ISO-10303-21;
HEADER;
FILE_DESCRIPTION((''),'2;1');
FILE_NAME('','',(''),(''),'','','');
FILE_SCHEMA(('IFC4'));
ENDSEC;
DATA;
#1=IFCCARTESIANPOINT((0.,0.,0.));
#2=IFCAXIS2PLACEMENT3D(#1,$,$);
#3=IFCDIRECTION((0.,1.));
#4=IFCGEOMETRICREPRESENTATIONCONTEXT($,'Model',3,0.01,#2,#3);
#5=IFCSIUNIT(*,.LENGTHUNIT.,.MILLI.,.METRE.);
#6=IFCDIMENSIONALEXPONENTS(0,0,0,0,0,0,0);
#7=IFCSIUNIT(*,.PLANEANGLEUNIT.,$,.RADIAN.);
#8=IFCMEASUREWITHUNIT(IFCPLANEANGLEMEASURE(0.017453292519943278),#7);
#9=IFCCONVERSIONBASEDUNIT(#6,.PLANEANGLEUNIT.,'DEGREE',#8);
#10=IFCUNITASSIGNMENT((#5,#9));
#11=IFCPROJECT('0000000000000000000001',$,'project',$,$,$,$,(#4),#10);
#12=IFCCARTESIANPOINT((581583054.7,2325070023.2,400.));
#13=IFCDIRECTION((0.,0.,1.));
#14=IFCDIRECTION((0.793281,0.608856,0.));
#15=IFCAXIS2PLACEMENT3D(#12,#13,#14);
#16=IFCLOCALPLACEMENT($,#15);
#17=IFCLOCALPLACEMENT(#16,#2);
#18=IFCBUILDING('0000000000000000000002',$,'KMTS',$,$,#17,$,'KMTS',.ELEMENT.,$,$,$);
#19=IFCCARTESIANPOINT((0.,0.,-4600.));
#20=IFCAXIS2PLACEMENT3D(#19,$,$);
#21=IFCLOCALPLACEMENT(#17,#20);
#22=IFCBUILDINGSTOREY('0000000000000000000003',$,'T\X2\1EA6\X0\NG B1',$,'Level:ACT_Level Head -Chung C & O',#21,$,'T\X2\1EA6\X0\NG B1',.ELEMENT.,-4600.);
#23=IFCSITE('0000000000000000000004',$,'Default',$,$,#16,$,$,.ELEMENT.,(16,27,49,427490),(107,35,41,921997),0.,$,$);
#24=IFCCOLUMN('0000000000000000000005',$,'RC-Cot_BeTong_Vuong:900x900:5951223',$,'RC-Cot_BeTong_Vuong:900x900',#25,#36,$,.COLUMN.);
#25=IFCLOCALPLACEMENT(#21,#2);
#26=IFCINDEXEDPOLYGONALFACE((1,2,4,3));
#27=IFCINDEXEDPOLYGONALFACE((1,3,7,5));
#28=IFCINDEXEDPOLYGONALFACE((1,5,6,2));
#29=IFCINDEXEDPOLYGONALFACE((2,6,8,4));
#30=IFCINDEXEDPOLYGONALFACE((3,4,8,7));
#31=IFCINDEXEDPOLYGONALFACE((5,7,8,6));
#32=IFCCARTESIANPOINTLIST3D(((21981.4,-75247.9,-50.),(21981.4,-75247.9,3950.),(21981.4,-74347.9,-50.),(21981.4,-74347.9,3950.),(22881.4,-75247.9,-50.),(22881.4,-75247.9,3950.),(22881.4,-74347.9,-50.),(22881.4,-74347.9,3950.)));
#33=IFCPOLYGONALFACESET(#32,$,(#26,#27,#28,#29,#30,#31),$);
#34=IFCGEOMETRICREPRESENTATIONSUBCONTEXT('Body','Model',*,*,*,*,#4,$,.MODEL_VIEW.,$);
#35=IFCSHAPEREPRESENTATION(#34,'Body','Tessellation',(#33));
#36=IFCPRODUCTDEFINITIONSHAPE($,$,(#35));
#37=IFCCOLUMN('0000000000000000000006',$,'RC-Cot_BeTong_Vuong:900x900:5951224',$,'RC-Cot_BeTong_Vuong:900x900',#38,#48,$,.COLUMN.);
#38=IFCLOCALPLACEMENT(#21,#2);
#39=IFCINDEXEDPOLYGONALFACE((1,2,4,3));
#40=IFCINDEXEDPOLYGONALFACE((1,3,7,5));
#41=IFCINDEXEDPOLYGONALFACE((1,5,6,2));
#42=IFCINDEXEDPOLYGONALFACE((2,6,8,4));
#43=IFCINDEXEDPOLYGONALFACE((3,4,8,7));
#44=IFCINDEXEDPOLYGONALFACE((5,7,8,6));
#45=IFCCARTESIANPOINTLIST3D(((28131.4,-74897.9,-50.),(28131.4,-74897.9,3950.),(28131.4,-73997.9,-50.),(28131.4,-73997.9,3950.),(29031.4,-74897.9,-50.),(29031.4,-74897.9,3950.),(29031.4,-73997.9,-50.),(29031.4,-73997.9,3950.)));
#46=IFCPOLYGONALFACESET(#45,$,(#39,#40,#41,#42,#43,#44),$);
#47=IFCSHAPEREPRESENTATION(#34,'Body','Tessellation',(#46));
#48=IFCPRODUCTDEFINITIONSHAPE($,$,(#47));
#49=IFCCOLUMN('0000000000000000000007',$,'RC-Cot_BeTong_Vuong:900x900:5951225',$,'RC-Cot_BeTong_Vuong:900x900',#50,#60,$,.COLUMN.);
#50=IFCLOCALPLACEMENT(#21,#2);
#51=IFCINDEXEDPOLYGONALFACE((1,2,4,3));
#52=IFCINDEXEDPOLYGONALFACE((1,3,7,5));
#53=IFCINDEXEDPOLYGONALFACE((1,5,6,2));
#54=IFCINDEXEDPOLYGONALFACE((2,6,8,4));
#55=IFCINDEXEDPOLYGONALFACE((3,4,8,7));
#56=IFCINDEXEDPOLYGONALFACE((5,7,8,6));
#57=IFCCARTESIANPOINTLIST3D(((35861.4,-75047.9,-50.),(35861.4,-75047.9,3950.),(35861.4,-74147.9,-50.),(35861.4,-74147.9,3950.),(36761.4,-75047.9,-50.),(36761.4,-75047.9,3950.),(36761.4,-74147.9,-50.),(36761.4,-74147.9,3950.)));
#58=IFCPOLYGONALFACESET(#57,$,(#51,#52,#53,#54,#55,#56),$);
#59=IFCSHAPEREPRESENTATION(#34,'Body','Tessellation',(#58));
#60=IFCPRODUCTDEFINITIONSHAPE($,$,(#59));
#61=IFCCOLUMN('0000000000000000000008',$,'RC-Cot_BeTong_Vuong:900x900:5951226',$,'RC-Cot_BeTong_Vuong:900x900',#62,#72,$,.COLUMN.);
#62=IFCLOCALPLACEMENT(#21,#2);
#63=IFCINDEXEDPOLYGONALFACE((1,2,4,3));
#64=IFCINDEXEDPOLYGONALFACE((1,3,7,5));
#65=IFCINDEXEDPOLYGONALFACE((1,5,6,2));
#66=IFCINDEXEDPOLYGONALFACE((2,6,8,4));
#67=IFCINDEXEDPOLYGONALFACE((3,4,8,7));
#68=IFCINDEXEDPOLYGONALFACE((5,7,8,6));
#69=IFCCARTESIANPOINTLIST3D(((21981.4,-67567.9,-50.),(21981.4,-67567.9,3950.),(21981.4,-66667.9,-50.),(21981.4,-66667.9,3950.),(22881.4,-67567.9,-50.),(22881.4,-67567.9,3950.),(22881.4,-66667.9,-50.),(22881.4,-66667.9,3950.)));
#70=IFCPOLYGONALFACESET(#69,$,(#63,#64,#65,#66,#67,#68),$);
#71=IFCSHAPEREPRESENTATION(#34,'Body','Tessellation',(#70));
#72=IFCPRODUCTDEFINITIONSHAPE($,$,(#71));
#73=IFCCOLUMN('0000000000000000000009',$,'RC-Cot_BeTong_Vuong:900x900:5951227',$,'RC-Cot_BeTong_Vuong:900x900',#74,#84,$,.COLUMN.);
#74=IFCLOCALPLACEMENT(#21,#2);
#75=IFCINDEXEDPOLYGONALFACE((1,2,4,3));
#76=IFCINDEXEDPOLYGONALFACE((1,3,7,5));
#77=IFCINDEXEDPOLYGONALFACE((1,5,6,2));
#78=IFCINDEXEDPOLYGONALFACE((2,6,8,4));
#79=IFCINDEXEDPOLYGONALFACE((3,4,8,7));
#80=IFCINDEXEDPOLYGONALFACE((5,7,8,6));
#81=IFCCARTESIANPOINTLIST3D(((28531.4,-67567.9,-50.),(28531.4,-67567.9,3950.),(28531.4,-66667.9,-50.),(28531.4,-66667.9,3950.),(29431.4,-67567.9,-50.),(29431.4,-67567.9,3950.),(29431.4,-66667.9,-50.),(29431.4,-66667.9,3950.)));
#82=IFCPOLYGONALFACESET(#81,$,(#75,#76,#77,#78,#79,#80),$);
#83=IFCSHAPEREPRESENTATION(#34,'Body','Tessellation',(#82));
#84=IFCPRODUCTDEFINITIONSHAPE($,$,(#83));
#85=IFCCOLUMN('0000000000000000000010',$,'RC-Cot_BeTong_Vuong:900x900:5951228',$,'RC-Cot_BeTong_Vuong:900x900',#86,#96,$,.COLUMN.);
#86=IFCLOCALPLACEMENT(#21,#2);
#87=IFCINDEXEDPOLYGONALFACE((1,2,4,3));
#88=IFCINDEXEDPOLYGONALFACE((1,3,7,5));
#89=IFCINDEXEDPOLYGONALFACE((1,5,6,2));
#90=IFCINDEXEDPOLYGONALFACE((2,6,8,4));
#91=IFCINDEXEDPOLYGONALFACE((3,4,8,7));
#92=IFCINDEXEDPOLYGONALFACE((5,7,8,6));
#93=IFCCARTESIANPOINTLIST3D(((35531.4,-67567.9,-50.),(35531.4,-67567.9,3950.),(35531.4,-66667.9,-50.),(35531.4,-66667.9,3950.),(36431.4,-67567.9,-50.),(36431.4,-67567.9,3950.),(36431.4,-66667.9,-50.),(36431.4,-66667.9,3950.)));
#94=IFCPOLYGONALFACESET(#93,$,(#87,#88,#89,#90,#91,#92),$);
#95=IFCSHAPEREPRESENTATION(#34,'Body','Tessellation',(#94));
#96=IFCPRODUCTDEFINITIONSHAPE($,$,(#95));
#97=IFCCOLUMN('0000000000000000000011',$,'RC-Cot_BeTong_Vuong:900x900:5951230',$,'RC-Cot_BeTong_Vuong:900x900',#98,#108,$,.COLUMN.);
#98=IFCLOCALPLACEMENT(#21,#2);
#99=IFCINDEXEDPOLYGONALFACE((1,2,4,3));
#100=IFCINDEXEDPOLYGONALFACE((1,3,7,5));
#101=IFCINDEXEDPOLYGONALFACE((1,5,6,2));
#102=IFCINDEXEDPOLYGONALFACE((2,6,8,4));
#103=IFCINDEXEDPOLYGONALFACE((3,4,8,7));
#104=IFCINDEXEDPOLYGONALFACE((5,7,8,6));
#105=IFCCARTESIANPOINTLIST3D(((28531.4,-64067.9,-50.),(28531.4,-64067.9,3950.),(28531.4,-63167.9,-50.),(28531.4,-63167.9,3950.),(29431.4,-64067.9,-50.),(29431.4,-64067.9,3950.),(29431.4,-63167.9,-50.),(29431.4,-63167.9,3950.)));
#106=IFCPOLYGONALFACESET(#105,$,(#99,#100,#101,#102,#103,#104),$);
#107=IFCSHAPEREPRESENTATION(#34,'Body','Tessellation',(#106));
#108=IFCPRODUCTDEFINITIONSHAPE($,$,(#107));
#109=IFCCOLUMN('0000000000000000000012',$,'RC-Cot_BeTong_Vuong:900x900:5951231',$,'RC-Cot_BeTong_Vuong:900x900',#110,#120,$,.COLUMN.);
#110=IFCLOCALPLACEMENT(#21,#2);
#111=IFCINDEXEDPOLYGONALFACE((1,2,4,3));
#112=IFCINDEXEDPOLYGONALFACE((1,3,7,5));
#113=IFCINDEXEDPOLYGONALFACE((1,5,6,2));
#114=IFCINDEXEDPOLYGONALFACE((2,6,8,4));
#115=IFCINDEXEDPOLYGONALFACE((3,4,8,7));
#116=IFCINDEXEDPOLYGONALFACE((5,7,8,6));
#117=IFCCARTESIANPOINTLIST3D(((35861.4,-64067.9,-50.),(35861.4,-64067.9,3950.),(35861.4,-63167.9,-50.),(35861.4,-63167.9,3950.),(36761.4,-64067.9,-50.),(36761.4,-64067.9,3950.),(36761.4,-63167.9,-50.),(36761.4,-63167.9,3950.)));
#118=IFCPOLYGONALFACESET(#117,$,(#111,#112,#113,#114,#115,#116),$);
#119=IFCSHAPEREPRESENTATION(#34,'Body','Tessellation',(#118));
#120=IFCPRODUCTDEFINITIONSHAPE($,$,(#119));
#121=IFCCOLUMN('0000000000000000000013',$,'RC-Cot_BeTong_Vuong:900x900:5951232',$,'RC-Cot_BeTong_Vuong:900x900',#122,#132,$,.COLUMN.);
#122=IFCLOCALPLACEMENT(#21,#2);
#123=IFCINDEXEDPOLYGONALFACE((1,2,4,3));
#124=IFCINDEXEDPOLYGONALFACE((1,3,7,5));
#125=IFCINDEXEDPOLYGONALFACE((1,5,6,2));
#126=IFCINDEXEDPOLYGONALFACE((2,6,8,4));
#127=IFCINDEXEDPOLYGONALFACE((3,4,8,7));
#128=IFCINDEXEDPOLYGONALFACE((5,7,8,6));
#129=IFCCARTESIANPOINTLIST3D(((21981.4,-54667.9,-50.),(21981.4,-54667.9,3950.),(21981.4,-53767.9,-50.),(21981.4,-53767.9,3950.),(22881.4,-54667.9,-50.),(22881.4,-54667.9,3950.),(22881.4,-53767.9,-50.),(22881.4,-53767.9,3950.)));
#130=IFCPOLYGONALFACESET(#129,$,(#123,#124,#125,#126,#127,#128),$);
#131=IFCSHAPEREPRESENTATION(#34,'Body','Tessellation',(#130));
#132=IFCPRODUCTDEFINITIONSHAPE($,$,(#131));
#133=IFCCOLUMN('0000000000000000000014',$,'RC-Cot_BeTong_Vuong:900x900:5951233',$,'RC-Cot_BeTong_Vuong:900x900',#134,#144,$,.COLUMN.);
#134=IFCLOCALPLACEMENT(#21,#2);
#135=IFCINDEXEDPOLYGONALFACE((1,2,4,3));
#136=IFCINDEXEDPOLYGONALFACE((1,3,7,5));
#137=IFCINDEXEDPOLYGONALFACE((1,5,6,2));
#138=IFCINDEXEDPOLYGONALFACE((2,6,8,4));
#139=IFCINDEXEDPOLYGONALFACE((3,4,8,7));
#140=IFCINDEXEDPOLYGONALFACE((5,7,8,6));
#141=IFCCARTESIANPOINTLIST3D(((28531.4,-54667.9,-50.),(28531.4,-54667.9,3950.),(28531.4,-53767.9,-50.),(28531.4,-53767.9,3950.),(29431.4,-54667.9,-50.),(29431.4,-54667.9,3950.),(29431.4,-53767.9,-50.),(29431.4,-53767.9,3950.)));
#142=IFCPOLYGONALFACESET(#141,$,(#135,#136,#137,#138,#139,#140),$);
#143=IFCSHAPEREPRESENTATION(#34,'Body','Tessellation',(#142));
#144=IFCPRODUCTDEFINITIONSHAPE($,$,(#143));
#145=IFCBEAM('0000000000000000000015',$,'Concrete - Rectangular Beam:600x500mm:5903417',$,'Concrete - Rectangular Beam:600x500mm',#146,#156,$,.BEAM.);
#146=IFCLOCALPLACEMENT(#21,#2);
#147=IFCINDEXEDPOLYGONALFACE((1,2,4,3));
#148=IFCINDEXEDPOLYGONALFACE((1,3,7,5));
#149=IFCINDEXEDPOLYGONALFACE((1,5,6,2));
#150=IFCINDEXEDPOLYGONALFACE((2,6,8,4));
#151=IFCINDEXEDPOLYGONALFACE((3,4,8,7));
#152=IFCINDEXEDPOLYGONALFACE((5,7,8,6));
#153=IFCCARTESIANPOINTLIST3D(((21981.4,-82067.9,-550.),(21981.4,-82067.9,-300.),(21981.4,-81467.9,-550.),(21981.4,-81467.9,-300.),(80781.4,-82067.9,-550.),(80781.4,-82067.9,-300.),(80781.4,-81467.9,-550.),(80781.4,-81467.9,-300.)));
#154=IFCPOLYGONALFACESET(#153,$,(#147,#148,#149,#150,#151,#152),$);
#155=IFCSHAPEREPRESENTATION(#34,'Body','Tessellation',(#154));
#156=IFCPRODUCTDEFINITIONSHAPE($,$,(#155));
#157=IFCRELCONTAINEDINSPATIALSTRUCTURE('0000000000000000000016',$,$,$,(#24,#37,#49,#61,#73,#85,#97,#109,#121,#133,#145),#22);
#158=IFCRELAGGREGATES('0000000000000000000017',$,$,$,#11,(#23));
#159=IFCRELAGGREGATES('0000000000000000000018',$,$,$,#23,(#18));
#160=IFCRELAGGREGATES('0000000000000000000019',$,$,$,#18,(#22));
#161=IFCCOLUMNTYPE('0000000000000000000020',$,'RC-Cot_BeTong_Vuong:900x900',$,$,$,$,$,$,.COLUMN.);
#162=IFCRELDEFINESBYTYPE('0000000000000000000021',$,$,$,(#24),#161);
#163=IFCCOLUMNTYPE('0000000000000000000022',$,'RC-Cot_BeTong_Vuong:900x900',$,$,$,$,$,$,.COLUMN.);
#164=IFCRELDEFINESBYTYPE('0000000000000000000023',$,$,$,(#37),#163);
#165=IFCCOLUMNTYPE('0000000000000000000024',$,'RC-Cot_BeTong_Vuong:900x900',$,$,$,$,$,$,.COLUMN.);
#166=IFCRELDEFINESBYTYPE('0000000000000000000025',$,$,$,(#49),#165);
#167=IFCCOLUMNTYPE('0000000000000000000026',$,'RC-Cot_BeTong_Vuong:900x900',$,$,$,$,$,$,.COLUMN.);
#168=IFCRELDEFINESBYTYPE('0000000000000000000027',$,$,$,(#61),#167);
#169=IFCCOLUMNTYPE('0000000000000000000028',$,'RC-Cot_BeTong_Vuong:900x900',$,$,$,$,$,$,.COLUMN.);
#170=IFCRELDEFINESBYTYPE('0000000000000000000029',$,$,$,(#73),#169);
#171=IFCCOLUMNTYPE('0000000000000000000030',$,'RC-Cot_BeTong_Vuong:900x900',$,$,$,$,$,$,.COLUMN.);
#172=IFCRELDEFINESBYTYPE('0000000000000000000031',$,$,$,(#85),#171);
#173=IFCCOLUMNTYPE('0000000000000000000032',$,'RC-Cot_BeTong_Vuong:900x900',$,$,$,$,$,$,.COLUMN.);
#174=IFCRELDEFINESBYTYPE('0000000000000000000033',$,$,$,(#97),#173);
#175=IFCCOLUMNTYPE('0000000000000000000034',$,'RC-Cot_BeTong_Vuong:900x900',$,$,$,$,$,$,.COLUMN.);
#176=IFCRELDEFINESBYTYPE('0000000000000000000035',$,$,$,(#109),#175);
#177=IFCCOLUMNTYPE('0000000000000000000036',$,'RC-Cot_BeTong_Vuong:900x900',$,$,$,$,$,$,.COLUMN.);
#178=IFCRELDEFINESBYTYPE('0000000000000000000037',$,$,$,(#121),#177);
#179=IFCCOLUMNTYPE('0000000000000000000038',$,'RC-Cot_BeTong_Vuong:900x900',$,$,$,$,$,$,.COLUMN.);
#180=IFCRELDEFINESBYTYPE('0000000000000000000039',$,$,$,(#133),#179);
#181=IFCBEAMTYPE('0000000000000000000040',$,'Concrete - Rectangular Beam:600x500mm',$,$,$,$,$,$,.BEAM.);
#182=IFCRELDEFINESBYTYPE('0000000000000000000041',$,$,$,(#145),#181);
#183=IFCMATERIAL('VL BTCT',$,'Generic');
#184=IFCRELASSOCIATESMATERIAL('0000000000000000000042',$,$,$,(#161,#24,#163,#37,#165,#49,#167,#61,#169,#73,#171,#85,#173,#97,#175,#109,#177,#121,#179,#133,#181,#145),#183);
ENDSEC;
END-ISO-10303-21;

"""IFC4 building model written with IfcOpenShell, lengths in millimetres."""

from ifc_helpers import new_model, entity, si_unit, converted_unit, direction, frame, origin, place, context, subcontext, project, spatial, indexed_curve, outline, extrude, source, transform, mapped, material, type_object, type_shapes, element, save


model = new_model("IFC4")

# Units and contexts
model_context = context("Model", 3, precision=0.01, world=origin(), true_north=direction((0.0, 1.0)))
body_context = subcontext(model_context, "Body", "Model", "MODEL_VIEW")
ifc_project = project(units=[si_unit("LENGTHUNIT", "METRE", prefix="MILLI"), converted_unit("PLANEANGLEUNIT", "DEGREE", entity("IfcPlaneAngleMeasure", 0.017453292519943278), si_unit("PLANEANGLEUNIT", "RADIAN"), dimensions=[0, 0, 0, 0, 0, 0, 0])], contexts=[model_context])

# Site, building, storey
site_placement = place(None, frame((581583054.7, 2325070023.2, 400.0), z_axis=(0.0, 0.0, 1.0), x_axis=(0.793281, 0.608856, 0.0)))
site = spatial("IfcSite", under=ifc_project, at=site_placement, Name="Default", CompositionType="ELEMENT", RefLatitude=(16, 27, 49, 427490), RefLongitude=(107, 35, 41, 921997), RefElevation=0.0)
building_placement = place(site_placement, origin())
building = spatial("IfcBuilding", under=site, at=building_placement, Name="KMTS", LongName="KMTS", CompositionType="ELEMENT")
storey_placement = place(building_placement, frame((0.0, 0.0, -4600.0)))
storey = spatial("IfcBuildingStorey", under=building, at=storey_placement, Name="TẦNG B1", ObjectType="Level:ACT_Level Head -Chung C & O", LongName="TẦNG B1", CompositionType="ELEMENT", Elevation=-4600.0)

# Columns
ifc_material_1 = material(Name="VL BTCT", Category="Generic")
column_type_1 = type_object("IfcColumnType", Name="RC-Cot_BeTong_Vuong:900x900", PredefinedType="COLUMN", material=ifc_material_1)
shared_shape_1 = source(origin(), body_context, "Body", "SweptSolid", [
    extrude(outline(indexed_curve([(-450.0, -450.0), (450.0, -450.0), (450.0, 450.0), (-450.0, 450.0), (-450.0, -450.0)], self_intersect=False)), frame((22431.4, -74797.9, -4650.0), z_axis=(0.0, 0.0, 1.0), x_axis=(-1.0, 0.0, 0.0)), (0.0, 0.0, 1.0), 4000.0),
])
type_shapes(column_type_1, [shared_shape_1])
column_1_placement = place(storey_placement, frame((0.0, 0.0, 4600.0)))
element("IfcColumn", 1, at=column_1_placement, inside=storey, type_object=column_type_1, material=ifc_material_1, Name="RC-Cot_BeTong_Vuong:900x900:5951223", ObjectType="RC-Cot_BeTong_Vuong:900x900", PredefinedType="COLUMN", context=body_context, shape_type="MappedRepresentation", body=[
    mapped(shared_shape_1, transform((0.0, 0.0, 0.0), scale=1.0)),
])
column_type_2 = type_object("IfcColumnType", Name="RC-Cot_BeTong_Vuong:900x900", PredefinedType="COLUMN", material=ifc_material_1)
shared_shape_2 = source(origin(), body_context, "Body", "SweptSolid", [
    extrude(outline(indexed_curve([(-450.0, -450.0), (450.0, -450.0), (450.0, 450.0), (-450.0, 450.0), (-450.0, -450.0)], self_intersect=False)), frame((28581.4, -74447.9, -4650.0), z_axis=(0.0, 0.0, 1.0), x_axis=(-1.0, 0.0, 0.0)), (0.0, 0.0, 1.0), 4000.0),
])
type_shapes(column_type_2, [shared_shape_2])
column_2_placement = place(storey_placement, frame((0.0, 0.0, 4600.0)))
element("IfcColumn", 2, at=column_2_placement, inside=storey, type_object=column_type_2, material=ifc_material_1, Name="RC-Cot_BeTong_Vuong:900x900:5951224", ObjectType="RC-Cot_BeTong_Vuong:900x900", PredefinedType="COLUMN", context=body_context, shape_type="MappedRepresentation", body=[
    mapped(shared_shape_2, transform((0.0, 0.0, 0.0), scale=1.0)),
])
column_type_3 = type_object("IfcColumnType", Name="RC-Cot_BeTong_Vuong:900x900", PredefinedType="COLUMN", material=ifc_material_1)
shared_shape_3 = source(origin(), body_context, "Body", "SweptSolid", [
    extrude(outline(indexed_curve([(-450.0, -450.0), (450.0, -450.0), (450.0, 450.0), (-450.0, 450.0), (-450.0, -450.0)], self_intersect=False)), frame((36311.4, -74597.9, -4650.0), z_axis=(0.0, 0.0, 1.0), x_axis=(-1.0, 0.0, 0.0)), (0.0, 0.0, 1.0), 4000.0),
])
type_shapes(column_type_3, [shared_shape_3])
column_3_placement = place(storey_placement, frame((0.0, 0.0, 4600.0)))
element("IfcColumn", 3, at=column_3_placement, inside=storey, type_object=column_type_3, material=ifc_material_1, Name="RC-Cot_BeTong_Vuong:900x900:5951225", ObjectType="RC-Cot_BeTong_Vuong:900x900", PredefinedType="COLUMN", context=body_context, shape_type="MappedRepresentation", body=[
    mapped(shared_shape_3, transform((0.0, 0.0, 0.0), scale=1.0)),
])
column_type_4 = type_object("IfcColumnType", Name="RC-Cot_BeTong_Vuong:900x900", PredefinedType="COLUMN", material=ifc_material_1)
shared_shape_4 = source(origin(), body_context, "Body", "SweptSolid", [
    extrude(outline(indexed_curve([(-450.0, -450.0), (450.0, -450.0), (450.0, 450.0), (-450.0, 450.0), (-450.0, -450.0)], self_intersect=False)), frame((22431.4, -67117.9, -4650.0), z_axis=(0.0, 0.0, 1.0), x_axis=(-1.0, 0.0, 0.0)), (0.0, 0.0, 1.0), 4000.0),
])
type_shapes(column_type_4, [shared_shape_4])
column_4_placement = place(storey_placement, frame((0.0, 0.0, 4600.0)))
element("IfcColumn", 4, at=column_4_placement, inside=storey, type_object=column_type_4, material=ifc_material_1, Name="RC-Cot_BeTong_Vuong:900x900:5951226", ObjectType="RC-Cot_BeTong_Vuong:900x900", PredefinedType="COLUMN", context=body_context, shape_type="MappedRepresentation", body=[
    mapped(shared_shape_4, transform((0.0, 0.0, 0.0), scale=1.0)),
])
column_type_5 = type_object("IfcColumnType", Name="RC-Cot_BeTong_Vuong:900x900", PredefinedType="COLUMN", material=ifc_material_1)
shared_shape_5 = source(origin(), body_context, "Body", "SweptSolid", [
    extrude(outline(indexed_curve([(-450.0, -450.0), (450.0, -450.0), (450.0, 450.0), (-450.0, 450.0), (-450.0, -450.0)], self_intersect=False)), frame((28981.4, -67117.9, -4650.0), z_axis=(0.0, 0.0, 1.0), x_axis=(-1.0, 0.0, 0.0)), (0.0, 0.0, 1.0), 4000.0),
])
type_shapes(column_type_5, [shared_shape_5])
column_5_placement = place(storey_placement, frame((0.0, 0.0, 4600.0)))
element("IfcColumn", 5, at=column_5_placement, inside=storey, type_object=column_type_5, material=ifc_material_1, Name="RC-Cot_BeTong_Vuong:900x900:5951227", ObjectType="RC-Cot_BeTong_Vuong:900x900", PredefinedType="COLUMN", context=body_context, shape_type="MappedRepresentation", body=[
    mapped(shared_shape_5, transform((0.0, 0.0, 0.0), scale=1.0)),
])
column_type_6 = type_object("IfcColumnType", Name="RC-Cot_BeTong_Vuong:900x900", PredefinedType="COLUMN", material=ifc_material_1)
shared_shape_6 = source(origin(), body_context, "Body", "SweptSolid", [
    extrude(outline(indexed_curve([(-450.0, -450.0), (450.0, -450.0), (450.0, 450.0), (-450.0, 450.0), (-450.0, -450.0)], self_intersect=False)), frame((35981.4, -67117.9, -4650.0), z_axis=(0.0, 0.0, 1.0), x_axis=(-1.0, 0.0, 0.0)), (0.0, 0.0, 1.0), 4000.0),
])
type_shapes(column_type_6, [shared_shape_6])
column_6_placement = place(storey_placement, frame((0.0, 0.0, 4600.0)))
element("IfcColumn", 6, at=column_6_placement, inside=storey, type_object=column_type_6, material=ifc_material_1, Name="RC-Cot_BeTong_Vuong:900x900:5951228", ObjectType="RC-Cot_BeTong_Vuong:900x900", PredefinedType="COLUMN", context=body_context, shape_type="MappedRepresentation", body=[
    mapped(shared_shape_6, transform((0.0, 0.0, 0.0), scale=1.0)),
])
column_type_7 = type_object("IfcColumnType", Name="RC-Cot_BeTong_Vuong:900x900", PredefinedType="COLUMN", material=ifc_material_1)
shared_shape_7 = source(origin(), body_context, "Body", "SweptSolid", [
    extrude(outline(indexed_curve([(-450.0, -450.0), (450.0, -450.0), (450.0, 450.0), (-450.0, 450.0), (-450.0, -450.0)], self_intersect=False)), frame((28981.4, -63617.9, -4650.0), z_axis=(0.0, 0.0, 1.0), x_axis=(-1.0, 0.0, 0.0)), (0.0, 0.0, 1.0), 4000.0),
])
type_shapes(column_type_7, [shared_shape_7])
column_7_placement = place(storey_placement, frame((0.0, 0.0, 4600.0)))
element("IfcColumn", 7, at=column_7_placement, inside=storey, type_object=column_type_7, material=ifc_material_1, Name="RC-Cot_BeTong_Vuong:900x900:5951230", ObjectType="RC-Cot_BeTong_Vuong:900x900", PredefinedType="COLUMN", context=body_context, shape_type="MappedRepresentation", body=[
    mapped(shared_shape_7, transform((0.0, 0.0, 0.0), scale=1.0)),
])
column_type_8 = type_object("IfcColumnType", Name="RC-Cot_BeTong_Vuong:900x900", PredefinedType="COLUMN", material=ifc_material_1)
shared_shape_8 = source(origin(), body_context, "Body", "SweptSolid", [
    extrude(outline(indexed_curve([(-450.0, -450.0), (450.0, -450.0), (450.0, 450.0), (-450.0, 450.0), (-450.0, -450.0)], self_intersect=False)), frame((36311.4, -63617.9, -4650.0), z_axis=(0.0, 0.0, 1.0), x_axis=(-1.0, 0.0, 0.0)), (0.0, 0.0, 1.0), 4000.0),
])
type_shapes(column_type_8, [shared_shape_8])
column_8_placement = place(storey_placement, frame((0.0, 0.0, 4600.0)))
element("IfcColumn", 8, at=column_8_placement, inside=storey, type_object=column_type_8, material=ifc_material_1, Name="RC-Cot_BeTong_Vuong:900x900:5951231", ObjectType="RC-Cot_BeTong_Vuong:900x900", PredefinedType="COLUMN", context=body_context, shape_type="MappedRepresentation", body=[
    mapped(shared_shape_8, transform((0.0, 0.0, 0.0), scale=1.0)),
])
column_type_9 = type_object("IfcColumnType", Name="RC-Cot_BeTong_Vuong:900x900", PredefinedType="COLUMN", material=ifc_material_1)
shared_shape_9 = source(origin(), body_context, "Body", "SweptSolid", [
    extrude(outline(indexed_curve([(-450.0, -450.0), (450.0, -450.0), (450.0, 450.0), (-450.0, 450.0), (-450.0, -450.0)], self_intersect=False)), frame((22431.4, -54217.9, -4650.0), z_axis=(0.0, 0.0, 1.0), x_axis=(-1.0, 0.0, 0.0)), (0.0, 0.0, 1.0), 4000.0),
])
type_shapes(column_type_9, [shared_shape_9])
column_9_placement = place(storey_placement, frame((0.0, 0.0, 4600.0)))
element("IfcColumn", 9, at=column_9_placement, inside=storey, type_object=column_type_9, material=ifc_material_1, Name="RC-Cot_BeTong_Vuong:900x900:5951232", ObjectType="RC-Cot_BeTong_Vuong:900x900", PredefinedType="COLUMN", context=body_context, shape_type="MappedRepresentation", body=[
    mapped(shared_shape_9, transform((0.0, 0.0, 0.0), scale=1.0)),
])
column_type_10 = type_object("IfcColumnType", Name="RC-Cot_BeTong_Vuong:900x900", PredefinedType="COLUMN", material=ifc_material_1)
shared_shape_10 = source(origin(), body_context, "Body", "SweptSolid", [
    extrude(outline(indexed_curve([(-450.0, -450.0), (450.0, -450.0), (450.0, 450.0), (-450.0, 450.0), (-450.0, -450.0)], self_intersect=False)), frame((28981.4, -54217.9, -4650.0), z_axis=(0.0, 0.0, 1.0), x_axis=(-1.0, 0.0, 0.0)), (0.0, 0.0, 1.0), 4000.0),
])
type_shapes(column_type_10, [shared_shape_10])
column_10_placement = place(storey_placement, frame((0.0, 0.0, 4600.0)))
element("IfcColumn", 10, at=column_10_placement, inside=storey, type_object=column_type_10, material=ifc_material_1, Name="RC-Cot_BeTong_Vuong:900x900:5951233", ObjectType="RC-Cot_BeTong_Vuong:900x900", PredefinedType="COLUMN", context=body_context, shape_type="MappedRepresentation", body=[
    mapped(shared_shape_10, transform((0.0, 0.0, 0.0), scale=1.0)),
])

# Beam
beam_type_1 = type_object("IfcBeamType", Name="Concrete - Rectangular Beam:600x500mm", PredefinedType="BEAM", material=ifc_material_1)
shared_shape_11 = source(origin(), body_context, "Body", "SweptSolid", [
    extrude(outline(indexed_curve([(-125.0, -300.0), (125.0, -300.0), (125.0, 300.0), (-125.0, 300.0), (-125.0, -300.0)], self_intersect=False)), frame((80781.4, -81767.9, -5025.0), z_axis=(-1.0, 0.0, 0.0), x_axis=(0.0, 0.0, -1.0)), (0.0, 0.0, 1.0), 58800.0),
])
type_shapes(beam_type_1, [shared_shape_11])
beam_1_placement = place(storey_placement, frame((0.0, 0.0, 4600.0)))
element("IfcBeam", 11, at=beam_1_placement, inside=storey, type_object=beam_type_1, material=ifc_material_1, Name="Concrete - Rectangular Beam:600x500mm:5903417", ObjectType="Concrete - Rectangular Beam:600x500mm", PredefinedType="BEAM", context=body_context, shape_type="MappedRepresentation", body=[
    mapped(shared_shape_11, transform((0.0, 0.0, 0.0), scale=1.0)),
])

save(model, "model.ifc")
